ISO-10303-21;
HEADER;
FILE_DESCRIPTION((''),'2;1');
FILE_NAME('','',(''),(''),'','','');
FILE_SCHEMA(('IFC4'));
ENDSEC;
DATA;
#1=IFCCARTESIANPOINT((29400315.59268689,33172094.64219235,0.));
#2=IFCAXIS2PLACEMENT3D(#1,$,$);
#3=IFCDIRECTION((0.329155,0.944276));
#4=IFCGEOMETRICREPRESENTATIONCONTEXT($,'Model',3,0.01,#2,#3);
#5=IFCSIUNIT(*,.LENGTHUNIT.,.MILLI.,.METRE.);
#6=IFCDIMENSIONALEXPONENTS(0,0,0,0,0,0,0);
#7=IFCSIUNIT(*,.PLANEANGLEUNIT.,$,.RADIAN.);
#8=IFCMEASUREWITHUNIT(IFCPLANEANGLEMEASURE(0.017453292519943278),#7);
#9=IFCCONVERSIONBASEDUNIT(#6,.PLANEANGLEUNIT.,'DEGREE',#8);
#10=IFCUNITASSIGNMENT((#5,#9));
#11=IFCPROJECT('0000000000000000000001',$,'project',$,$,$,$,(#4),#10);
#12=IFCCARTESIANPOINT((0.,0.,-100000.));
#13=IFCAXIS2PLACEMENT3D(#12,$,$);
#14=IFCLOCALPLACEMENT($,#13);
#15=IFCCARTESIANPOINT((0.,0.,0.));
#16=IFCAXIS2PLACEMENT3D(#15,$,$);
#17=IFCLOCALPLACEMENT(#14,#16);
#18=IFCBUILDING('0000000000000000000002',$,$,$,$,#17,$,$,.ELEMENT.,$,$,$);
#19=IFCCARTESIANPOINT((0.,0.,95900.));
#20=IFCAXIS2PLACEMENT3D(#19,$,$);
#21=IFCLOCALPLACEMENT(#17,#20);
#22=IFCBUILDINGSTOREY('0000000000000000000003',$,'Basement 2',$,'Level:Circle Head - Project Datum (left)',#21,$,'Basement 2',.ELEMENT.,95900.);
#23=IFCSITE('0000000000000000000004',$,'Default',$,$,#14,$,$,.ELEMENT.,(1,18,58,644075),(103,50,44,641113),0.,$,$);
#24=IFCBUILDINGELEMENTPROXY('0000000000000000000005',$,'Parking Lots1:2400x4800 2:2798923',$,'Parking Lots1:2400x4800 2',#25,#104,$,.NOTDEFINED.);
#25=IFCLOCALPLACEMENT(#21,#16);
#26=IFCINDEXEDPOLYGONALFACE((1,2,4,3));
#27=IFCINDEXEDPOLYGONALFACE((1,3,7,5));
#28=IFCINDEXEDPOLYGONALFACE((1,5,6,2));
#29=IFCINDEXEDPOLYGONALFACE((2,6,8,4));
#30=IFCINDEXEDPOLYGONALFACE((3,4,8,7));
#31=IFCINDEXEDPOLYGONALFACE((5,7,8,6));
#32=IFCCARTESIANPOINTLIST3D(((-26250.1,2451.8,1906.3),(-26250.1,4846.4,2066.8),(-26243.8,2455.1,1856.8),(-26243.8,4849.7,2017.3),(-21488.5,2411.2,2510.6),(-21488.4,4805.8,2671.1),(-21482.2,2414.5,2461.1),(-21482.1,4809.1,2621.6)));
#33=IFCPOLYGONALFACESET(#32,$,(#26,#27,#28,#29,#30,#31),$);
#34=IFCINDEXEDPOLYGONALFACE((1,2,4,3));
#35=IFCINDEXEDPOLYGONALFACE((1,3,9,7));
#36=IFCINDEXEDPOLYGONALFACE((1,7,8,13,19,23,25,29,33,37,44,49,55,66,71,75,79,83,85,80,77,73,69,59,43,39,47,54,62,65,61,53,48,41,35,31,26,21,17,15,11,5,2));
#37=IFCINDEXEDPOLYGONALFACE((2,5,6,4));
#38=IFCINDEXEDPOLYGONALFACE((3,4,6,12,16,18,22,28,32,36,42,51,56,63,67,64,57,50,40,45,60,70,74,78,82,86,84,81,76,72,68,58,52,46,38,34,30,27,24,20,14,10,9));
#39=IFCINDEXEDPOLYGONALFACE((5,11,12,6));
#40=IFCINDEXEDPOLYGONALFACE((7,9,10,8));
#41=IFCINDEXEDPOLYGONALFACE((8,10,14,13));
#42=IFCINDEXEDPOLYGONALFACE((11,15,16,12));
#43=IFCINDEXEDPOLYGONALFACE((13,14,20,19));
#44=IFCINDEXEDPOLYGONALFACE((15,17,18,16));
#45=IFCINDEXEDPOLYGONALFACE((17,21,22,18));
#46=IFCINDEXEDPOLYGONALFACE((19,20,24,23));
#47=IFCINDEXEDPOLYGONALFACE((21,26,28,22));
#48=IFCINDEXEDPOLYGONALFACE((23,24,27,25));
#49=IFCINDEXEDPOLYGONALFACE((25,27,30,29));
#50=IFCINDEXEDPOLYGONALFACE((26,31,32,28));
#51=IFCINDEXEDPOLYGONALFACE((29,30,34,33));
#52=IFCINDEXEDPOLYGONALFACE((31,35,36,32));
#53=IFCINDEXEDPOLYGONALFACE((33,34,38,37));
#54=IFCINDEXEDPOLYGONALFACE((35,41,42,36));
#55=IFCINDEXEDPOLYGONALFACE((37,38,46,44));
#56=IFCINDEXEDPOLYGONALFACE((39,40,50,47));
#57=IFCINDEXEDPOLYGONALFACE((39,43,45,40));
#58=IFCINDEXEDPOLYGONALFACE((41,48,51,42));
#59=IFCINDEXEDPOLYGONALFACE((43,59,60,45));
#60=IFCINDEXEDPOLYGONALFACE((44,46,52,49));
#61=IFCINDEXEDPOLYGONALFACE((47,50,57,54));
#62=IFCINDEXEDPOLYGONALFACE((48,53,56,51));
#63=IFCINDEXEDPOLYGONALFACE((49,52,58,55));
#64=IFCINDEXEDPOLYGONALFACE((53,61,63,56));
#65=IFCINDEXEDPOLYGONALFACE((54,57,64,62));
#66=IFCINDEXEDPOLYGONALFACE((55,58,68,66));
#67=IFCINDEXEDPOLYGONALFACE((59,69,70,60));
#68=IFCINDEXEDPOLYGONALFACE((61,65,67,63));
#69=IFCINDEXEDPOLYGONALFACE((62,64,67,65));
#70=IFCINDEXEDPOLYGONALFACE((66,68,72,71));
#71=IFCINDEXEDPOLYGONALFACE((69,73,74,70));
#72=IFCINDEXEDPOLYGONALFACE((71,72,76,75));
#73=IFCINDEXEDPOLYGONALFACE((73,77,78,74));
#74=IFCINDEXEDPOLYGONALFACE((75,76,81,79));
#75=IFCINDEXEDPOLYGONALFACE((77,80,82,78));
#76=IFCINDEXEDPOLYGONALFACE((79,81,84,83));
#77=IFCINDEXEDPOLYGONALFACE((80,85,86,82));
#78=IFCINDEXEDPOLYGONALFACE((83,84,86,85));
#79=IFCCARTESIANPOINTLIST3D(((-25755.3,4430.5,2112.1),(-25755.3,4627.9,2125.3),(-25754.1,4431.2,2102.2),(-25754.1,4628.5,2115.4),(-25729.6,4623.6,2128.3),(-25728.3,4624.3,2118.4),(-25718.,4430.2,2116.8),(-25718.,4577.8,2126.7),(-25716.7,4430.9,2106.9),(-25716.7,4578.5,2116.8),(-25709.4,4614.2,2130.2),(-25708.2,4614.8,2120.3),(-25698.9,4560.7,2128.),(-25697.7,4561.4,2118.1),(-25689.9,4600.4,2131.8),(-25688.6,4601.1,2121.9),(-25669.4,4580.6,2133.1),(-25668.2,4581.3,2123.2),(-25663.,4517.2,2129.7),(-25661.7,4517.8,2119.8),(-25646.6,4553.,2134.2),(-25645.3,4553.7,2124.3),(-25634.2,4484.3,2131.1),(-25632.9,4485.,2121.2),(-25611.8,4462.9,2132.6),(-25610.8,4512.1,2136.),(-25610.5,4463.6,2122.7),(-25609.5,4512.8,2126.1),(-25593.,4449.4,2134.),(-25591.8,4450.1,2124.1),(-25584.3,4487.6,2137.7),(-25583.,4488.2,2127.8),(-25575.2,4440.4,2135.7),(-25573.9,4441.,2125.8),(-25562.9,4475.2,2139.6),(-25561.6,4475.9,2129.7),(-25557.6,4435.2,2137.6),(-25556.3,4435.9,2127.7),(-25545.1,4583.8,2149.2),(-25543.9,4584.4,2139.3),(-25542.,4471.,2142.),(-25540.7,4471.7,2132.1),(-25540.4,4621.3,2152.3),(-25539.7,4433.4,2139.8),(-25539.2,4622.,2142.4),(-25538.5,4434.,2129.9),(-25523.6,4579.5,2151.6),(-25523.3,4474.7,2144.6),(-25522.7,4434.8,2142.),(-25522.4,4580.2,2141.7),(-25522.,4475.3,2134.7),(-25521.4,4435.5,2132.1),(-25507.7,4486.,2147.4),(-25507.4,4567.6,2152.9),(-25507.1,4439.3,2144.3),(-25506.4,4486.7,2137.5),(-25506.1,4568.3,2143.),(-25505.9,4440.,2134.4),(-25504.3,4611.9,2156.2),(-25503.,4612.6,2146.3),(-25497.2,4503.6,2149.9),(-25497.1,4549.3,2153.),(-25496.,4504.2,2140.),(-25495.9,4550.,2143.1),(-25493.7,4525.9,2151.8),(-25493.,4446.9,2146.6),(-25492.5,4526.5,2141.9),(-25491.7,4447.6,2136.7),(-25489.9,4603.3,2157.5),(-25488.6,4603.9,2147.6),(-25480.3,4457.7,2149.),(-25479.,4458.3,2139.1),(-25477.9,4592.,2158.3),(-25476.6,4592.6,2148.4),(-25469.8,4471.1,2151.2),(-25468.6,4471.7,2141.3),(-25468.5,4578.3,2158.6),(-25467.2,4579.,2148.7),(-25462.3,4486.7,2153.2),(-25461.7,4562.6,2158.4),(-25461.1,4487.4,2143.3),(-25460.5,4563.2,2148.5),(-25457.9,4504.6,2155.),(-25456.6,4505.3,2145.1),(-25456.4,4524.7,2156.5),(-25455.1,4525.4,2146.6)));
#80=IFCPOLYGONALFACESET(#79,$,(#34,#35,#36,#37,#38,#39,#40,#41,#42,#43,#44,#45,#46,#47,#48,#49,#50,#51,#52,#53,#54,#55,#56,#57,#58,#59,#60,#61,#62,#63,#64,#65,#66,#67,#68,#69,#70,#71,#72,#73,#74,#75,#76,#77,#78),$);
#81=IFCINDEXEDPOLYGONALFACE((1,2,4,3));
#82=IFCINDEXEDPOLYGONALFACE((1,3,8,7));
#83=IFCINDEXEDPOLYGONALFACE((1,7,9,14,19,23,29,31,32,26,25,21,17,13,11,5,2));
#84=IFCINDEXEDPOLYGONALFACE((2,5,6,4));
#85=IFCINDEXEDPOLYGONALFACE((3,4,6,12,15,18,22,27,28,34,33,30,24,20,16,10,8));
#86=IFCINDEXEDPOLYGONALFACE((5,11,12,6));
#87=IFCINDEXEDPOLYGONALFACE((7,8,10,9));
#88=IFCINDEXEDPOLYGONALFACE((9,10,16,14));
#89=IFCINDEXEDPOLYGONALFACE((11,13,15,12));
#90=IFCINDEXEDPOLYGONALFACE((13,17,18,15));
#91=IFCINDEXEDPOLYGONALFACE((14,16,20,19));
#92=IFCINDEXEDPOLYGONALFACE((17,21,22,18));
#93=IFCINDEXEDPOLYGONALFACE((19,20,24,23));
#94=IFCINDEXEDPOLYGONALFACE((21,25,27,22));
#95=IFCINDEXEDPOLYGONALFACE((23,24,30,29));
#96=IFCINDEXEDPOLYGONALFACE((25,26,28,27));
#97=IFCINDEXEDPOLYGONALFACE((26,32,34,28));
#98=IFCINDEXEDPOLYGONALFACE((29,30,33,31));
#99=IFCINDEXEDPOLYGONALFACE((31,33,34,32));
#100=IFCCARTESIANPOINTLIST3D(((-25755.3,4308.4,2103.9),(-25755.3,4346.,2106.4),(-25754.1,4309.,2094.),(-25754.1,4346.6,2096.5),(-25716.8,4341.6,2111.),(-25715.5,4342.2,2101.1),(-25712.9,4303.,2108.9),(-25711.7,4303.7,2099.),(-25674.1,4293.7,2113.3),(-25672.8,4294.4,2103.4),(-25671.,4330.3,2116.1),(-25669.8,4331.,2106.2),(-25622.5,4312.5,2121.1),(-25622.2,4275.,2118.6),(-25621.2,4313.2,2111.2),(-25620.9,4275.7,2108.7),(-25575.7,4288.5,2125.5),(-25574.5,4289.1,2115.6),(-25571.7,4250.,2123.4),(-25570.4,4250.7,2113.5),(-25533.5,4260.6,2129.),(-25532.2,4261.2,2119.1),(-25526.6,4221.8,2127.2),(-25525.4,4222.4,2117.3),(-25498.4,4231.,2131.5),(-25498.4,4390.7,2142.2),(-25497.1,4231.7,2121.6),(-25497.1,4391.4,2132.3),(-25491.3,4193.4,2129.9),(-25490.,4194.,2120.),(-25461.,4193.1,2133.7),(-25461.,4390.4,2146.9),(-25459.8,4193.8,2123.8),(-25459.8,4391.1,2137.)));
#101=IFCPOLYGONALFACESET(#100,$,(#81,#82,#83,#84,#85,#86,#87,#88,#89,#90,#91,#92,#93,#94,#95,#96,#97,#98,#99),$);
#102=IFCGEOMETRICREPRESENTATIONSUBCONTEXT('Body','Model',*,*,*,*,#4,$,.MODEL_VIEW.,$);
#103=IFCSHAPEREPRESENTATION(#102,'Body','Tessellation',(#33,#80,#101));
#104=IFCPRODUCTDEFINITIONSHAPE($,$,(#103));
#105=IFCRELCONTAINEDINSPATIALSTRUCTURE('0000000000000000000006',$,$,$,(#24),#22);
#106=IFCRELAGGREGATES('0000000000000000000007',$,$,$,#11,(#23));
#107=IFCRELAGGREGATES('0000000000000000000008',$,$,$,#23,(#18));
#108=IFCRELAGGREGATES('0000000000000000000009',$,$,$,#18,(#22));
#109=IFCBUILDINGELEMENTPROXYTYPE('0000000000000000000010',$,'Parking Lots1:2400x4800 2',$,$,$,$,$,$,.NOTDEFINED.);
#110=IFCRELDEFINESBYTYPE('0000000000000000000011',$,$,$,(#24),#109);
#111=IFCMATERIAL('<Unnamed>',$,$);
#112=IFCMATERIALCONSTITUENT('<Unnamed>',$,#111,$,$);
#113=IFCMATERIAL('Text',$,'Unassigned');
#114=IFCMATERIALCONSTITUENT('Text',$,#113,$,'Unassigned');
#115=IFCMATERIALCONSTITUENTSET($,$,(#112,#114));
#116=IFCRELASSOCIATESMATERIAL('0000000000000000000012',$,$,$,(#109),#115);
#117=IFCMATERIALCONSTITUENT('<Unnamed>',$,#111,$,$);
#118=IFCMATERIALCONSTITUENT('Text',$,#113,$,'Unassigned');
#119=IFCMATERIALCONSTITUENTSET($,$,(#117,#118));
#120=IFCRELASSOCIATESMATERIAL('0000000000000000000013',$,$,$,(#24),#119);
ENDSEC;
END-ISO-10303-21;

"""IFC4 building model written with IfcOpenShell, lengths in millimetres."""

from ifc_helpers import new_model, entity, si_unit, converted_unit, direction, frame, origin, place, context, subcontext, project, spatial, indexed_curve, outline, extrude, source, transform, mapped, material, constituent, constituent_set, type_object, type_shapes, element, save


model = new_model("IFC4")

# Units and contexts
model_context = context("Model", 3, precision=0.01, world=frame((29400315.59268689, 33172094.64219235, 0.0)), true_north=direction((0.329155, 0.944276)))
body_context = subcontext(model_context, "Body", "Model", "MODEL_VIEW")
ifc_project = project(units=[si_unit("LENGTHUNIT", "METRE", prefix="MILLI"), converted_unit("PLANEANGLEUNIT", "DEGREE", entity("IfcPlaneAngleMeasure", 0.017453292519943278), si_unit("PLANEANGLEUNIT", "RADIAN"), dimensions=[0, 0, 0, 0, 0, 0, 0])], contexts=[model_context])

# Site, building, storey
site_placement = place(None, frame((0.0, 0.0, -100000.0)))
site = spatial("IfcSite", under=ifc_project, at=site_placement, Name="Default", CompositionType="ELEMENT", RefLatitude=(1, 18, 58, 644075), RefLongitude=(103, 50, 44, 641113), RefElevation=0.0)
building_placement = place(site_placement, origin())
building = spatial("IfcBuilding", under=site, at=building_placement, CompositionType="ELEMENT")
storey_placement = place(building_placement, frame((0.0, 0.0, 95900.0)))
storey = spatial("IfcBuildingStorey", under=building, at=storey_placement, Name="Basement 2", ObjectType="Level:Circle Head - Project Datum (left)", LongName="Basement 2", CompositionType="ELEMENT", Elevation=95900.0)

# Shared definitions
ifc_material_1 = material(Name="<Unnamed>")

# Building element proxy
ifc_constituent_1 = constituent(ifc_material_1, Name="<Unnamed>")
ifc_material_2 = material(Name="Text", Category="Unassigned")
ifc_constituent_2 = constituent(ifc_material_2, Name="Text", Category="Unassigned")
ifc_constituent_set_1 = constituent_set(constituents=[ifc_constituent_1, ifc_constituent_2])
ifc_constituent_3 = constituent(ifc_material_1, Name="<Unnamed>")
ifc_constituent_4 = constituent(ifc_material_2, Name="Text", Category="Unassigned")
ifc_constituent_set_2 = constituent_set(constituents=[ifc_constituent_3, ifc_constituent_4])
building_element_proxy_type_1 = type_object("IfcBuildingElementProxyType", Name="Parking Lots1:2400x4800 2", PredefinedType="NOTDEFINED", material=ifc_constituent_set_2)
shared_shape_1 = source(origin(), body_context, "Body", "SweptSolid", [
    extrude(outline(indexed_curve([(-1200.0, -2400.0), (1200.0, -2400.0), (1200.0, 2400.0), (-1200.0, 2400.0), (-1200.0, -2400.0)], self_intersect=False)), frame((1200.0, -2400.0, 0.0), z_axis=(0.0, 0.0, 1.0), x_axis=(-1.0, 0.0, 0.0)), (0.0, 0.0, 1.0), 50.0),
    extrude(outline(indexed_curve([(-91.6, -150.5), (-91.6, -188.2), (106.2, -188.2), (102.1, -162.2), (92.9, -141.9), (79.3, -122.2), (59.6, -101.6), (32.1, -78.5), (-8.5, -42.4), (-32.9, -15.8), (-45.1, 5.8), (-49.2, 26.9), (-45.4, 45.8), (-33.9, 61.4), (-16.2, 72.0), (6.2, 75.5), (29.7, 72.1), (48.0, 61.8), (59.7, 45.4), (63.8, 23.7), (101.5, 28.4), (92.4, 64.9), (83.8, 79.4), (72.6, 91.5), (59.0, 101.0), (43.3, 107.8), (5.4, 113.2), (-14.8, 111.7), (-32.8, 107.2), (-48.5, 99.6), (-62.0, 89.1), (-72.9, 76.3), (-80.7, 62.0), (-85.3, 46.3), (-86.9, 29.2), (-85.2, 11.2), (-80.2, -6.5), (-71.3, -24.6), (-57.9, -43.5), (-36.6, -66.1), (-3.9, -95.1), (39.4, -131.3), (56.4, -150.5), (-91.6, -150.5)], self_intersect=False)), frame((320.3, -4111.8, 50.0), z_axis=(0.0, 0.0, -1.0), x_axis=(-1.0, 0.0, 0.0)), (0.0, 0.0, -1.0), 10.0),
    extrude(outline(indexed_curve([(-101.8, -99.3), (-101.8, -137.0), (96.0, -137.0), (96.0, -106.5), (67.8, -70.9), (39.9, -25.5), (15.2, 25.4), (-3.1, 77.8), (-12.1, 116.9), (-17.1, 159.7), (-54.7, 159.7), (-50.7, 120.8), (-39.8, 74.7), (-22.3, 25.8), (1.3, -21.4), (29.0, -64.0), (58.3, -99.3), (-101.8, -99.3)], self_intersect=False)), frame((551.4, -4140.3, 50.0), z_axis=(0.0, 0.0, -1.0), x_axis=(1.0, 0.0, 0.0)), (0.0, 0.0, -1.0), 10.0),
])
type_shapes(building_element_proxy_type_1, [shared_shape_1])
proxy_1_placement = place(storey_placement, frame((-21482.1, 4809.1, 2621.6), z_axis=(-0.126185, -0.066337, 0.989786), x_axis=(-0.000014, -0.997761, -0.066874)))
element("IfcBuildingElementProxy", 1, at=proxy_1_placement, inside=storey, type_object=building_element_proxy_type_1, material=ifc_constituent_set_1, Name="Parking Lots1:2400x4800 2:2798923", ObjectType="Parking Lots1:2400x4800 2", PredefinedType="NOTDEFINED", context=body_context, shape_type="MappedRepresentation", body=[
    mapped(shared_shape_1, transform((0.0, 0.0, 0.0), scale=1.0)),
])

save(model, "model.ifc")
